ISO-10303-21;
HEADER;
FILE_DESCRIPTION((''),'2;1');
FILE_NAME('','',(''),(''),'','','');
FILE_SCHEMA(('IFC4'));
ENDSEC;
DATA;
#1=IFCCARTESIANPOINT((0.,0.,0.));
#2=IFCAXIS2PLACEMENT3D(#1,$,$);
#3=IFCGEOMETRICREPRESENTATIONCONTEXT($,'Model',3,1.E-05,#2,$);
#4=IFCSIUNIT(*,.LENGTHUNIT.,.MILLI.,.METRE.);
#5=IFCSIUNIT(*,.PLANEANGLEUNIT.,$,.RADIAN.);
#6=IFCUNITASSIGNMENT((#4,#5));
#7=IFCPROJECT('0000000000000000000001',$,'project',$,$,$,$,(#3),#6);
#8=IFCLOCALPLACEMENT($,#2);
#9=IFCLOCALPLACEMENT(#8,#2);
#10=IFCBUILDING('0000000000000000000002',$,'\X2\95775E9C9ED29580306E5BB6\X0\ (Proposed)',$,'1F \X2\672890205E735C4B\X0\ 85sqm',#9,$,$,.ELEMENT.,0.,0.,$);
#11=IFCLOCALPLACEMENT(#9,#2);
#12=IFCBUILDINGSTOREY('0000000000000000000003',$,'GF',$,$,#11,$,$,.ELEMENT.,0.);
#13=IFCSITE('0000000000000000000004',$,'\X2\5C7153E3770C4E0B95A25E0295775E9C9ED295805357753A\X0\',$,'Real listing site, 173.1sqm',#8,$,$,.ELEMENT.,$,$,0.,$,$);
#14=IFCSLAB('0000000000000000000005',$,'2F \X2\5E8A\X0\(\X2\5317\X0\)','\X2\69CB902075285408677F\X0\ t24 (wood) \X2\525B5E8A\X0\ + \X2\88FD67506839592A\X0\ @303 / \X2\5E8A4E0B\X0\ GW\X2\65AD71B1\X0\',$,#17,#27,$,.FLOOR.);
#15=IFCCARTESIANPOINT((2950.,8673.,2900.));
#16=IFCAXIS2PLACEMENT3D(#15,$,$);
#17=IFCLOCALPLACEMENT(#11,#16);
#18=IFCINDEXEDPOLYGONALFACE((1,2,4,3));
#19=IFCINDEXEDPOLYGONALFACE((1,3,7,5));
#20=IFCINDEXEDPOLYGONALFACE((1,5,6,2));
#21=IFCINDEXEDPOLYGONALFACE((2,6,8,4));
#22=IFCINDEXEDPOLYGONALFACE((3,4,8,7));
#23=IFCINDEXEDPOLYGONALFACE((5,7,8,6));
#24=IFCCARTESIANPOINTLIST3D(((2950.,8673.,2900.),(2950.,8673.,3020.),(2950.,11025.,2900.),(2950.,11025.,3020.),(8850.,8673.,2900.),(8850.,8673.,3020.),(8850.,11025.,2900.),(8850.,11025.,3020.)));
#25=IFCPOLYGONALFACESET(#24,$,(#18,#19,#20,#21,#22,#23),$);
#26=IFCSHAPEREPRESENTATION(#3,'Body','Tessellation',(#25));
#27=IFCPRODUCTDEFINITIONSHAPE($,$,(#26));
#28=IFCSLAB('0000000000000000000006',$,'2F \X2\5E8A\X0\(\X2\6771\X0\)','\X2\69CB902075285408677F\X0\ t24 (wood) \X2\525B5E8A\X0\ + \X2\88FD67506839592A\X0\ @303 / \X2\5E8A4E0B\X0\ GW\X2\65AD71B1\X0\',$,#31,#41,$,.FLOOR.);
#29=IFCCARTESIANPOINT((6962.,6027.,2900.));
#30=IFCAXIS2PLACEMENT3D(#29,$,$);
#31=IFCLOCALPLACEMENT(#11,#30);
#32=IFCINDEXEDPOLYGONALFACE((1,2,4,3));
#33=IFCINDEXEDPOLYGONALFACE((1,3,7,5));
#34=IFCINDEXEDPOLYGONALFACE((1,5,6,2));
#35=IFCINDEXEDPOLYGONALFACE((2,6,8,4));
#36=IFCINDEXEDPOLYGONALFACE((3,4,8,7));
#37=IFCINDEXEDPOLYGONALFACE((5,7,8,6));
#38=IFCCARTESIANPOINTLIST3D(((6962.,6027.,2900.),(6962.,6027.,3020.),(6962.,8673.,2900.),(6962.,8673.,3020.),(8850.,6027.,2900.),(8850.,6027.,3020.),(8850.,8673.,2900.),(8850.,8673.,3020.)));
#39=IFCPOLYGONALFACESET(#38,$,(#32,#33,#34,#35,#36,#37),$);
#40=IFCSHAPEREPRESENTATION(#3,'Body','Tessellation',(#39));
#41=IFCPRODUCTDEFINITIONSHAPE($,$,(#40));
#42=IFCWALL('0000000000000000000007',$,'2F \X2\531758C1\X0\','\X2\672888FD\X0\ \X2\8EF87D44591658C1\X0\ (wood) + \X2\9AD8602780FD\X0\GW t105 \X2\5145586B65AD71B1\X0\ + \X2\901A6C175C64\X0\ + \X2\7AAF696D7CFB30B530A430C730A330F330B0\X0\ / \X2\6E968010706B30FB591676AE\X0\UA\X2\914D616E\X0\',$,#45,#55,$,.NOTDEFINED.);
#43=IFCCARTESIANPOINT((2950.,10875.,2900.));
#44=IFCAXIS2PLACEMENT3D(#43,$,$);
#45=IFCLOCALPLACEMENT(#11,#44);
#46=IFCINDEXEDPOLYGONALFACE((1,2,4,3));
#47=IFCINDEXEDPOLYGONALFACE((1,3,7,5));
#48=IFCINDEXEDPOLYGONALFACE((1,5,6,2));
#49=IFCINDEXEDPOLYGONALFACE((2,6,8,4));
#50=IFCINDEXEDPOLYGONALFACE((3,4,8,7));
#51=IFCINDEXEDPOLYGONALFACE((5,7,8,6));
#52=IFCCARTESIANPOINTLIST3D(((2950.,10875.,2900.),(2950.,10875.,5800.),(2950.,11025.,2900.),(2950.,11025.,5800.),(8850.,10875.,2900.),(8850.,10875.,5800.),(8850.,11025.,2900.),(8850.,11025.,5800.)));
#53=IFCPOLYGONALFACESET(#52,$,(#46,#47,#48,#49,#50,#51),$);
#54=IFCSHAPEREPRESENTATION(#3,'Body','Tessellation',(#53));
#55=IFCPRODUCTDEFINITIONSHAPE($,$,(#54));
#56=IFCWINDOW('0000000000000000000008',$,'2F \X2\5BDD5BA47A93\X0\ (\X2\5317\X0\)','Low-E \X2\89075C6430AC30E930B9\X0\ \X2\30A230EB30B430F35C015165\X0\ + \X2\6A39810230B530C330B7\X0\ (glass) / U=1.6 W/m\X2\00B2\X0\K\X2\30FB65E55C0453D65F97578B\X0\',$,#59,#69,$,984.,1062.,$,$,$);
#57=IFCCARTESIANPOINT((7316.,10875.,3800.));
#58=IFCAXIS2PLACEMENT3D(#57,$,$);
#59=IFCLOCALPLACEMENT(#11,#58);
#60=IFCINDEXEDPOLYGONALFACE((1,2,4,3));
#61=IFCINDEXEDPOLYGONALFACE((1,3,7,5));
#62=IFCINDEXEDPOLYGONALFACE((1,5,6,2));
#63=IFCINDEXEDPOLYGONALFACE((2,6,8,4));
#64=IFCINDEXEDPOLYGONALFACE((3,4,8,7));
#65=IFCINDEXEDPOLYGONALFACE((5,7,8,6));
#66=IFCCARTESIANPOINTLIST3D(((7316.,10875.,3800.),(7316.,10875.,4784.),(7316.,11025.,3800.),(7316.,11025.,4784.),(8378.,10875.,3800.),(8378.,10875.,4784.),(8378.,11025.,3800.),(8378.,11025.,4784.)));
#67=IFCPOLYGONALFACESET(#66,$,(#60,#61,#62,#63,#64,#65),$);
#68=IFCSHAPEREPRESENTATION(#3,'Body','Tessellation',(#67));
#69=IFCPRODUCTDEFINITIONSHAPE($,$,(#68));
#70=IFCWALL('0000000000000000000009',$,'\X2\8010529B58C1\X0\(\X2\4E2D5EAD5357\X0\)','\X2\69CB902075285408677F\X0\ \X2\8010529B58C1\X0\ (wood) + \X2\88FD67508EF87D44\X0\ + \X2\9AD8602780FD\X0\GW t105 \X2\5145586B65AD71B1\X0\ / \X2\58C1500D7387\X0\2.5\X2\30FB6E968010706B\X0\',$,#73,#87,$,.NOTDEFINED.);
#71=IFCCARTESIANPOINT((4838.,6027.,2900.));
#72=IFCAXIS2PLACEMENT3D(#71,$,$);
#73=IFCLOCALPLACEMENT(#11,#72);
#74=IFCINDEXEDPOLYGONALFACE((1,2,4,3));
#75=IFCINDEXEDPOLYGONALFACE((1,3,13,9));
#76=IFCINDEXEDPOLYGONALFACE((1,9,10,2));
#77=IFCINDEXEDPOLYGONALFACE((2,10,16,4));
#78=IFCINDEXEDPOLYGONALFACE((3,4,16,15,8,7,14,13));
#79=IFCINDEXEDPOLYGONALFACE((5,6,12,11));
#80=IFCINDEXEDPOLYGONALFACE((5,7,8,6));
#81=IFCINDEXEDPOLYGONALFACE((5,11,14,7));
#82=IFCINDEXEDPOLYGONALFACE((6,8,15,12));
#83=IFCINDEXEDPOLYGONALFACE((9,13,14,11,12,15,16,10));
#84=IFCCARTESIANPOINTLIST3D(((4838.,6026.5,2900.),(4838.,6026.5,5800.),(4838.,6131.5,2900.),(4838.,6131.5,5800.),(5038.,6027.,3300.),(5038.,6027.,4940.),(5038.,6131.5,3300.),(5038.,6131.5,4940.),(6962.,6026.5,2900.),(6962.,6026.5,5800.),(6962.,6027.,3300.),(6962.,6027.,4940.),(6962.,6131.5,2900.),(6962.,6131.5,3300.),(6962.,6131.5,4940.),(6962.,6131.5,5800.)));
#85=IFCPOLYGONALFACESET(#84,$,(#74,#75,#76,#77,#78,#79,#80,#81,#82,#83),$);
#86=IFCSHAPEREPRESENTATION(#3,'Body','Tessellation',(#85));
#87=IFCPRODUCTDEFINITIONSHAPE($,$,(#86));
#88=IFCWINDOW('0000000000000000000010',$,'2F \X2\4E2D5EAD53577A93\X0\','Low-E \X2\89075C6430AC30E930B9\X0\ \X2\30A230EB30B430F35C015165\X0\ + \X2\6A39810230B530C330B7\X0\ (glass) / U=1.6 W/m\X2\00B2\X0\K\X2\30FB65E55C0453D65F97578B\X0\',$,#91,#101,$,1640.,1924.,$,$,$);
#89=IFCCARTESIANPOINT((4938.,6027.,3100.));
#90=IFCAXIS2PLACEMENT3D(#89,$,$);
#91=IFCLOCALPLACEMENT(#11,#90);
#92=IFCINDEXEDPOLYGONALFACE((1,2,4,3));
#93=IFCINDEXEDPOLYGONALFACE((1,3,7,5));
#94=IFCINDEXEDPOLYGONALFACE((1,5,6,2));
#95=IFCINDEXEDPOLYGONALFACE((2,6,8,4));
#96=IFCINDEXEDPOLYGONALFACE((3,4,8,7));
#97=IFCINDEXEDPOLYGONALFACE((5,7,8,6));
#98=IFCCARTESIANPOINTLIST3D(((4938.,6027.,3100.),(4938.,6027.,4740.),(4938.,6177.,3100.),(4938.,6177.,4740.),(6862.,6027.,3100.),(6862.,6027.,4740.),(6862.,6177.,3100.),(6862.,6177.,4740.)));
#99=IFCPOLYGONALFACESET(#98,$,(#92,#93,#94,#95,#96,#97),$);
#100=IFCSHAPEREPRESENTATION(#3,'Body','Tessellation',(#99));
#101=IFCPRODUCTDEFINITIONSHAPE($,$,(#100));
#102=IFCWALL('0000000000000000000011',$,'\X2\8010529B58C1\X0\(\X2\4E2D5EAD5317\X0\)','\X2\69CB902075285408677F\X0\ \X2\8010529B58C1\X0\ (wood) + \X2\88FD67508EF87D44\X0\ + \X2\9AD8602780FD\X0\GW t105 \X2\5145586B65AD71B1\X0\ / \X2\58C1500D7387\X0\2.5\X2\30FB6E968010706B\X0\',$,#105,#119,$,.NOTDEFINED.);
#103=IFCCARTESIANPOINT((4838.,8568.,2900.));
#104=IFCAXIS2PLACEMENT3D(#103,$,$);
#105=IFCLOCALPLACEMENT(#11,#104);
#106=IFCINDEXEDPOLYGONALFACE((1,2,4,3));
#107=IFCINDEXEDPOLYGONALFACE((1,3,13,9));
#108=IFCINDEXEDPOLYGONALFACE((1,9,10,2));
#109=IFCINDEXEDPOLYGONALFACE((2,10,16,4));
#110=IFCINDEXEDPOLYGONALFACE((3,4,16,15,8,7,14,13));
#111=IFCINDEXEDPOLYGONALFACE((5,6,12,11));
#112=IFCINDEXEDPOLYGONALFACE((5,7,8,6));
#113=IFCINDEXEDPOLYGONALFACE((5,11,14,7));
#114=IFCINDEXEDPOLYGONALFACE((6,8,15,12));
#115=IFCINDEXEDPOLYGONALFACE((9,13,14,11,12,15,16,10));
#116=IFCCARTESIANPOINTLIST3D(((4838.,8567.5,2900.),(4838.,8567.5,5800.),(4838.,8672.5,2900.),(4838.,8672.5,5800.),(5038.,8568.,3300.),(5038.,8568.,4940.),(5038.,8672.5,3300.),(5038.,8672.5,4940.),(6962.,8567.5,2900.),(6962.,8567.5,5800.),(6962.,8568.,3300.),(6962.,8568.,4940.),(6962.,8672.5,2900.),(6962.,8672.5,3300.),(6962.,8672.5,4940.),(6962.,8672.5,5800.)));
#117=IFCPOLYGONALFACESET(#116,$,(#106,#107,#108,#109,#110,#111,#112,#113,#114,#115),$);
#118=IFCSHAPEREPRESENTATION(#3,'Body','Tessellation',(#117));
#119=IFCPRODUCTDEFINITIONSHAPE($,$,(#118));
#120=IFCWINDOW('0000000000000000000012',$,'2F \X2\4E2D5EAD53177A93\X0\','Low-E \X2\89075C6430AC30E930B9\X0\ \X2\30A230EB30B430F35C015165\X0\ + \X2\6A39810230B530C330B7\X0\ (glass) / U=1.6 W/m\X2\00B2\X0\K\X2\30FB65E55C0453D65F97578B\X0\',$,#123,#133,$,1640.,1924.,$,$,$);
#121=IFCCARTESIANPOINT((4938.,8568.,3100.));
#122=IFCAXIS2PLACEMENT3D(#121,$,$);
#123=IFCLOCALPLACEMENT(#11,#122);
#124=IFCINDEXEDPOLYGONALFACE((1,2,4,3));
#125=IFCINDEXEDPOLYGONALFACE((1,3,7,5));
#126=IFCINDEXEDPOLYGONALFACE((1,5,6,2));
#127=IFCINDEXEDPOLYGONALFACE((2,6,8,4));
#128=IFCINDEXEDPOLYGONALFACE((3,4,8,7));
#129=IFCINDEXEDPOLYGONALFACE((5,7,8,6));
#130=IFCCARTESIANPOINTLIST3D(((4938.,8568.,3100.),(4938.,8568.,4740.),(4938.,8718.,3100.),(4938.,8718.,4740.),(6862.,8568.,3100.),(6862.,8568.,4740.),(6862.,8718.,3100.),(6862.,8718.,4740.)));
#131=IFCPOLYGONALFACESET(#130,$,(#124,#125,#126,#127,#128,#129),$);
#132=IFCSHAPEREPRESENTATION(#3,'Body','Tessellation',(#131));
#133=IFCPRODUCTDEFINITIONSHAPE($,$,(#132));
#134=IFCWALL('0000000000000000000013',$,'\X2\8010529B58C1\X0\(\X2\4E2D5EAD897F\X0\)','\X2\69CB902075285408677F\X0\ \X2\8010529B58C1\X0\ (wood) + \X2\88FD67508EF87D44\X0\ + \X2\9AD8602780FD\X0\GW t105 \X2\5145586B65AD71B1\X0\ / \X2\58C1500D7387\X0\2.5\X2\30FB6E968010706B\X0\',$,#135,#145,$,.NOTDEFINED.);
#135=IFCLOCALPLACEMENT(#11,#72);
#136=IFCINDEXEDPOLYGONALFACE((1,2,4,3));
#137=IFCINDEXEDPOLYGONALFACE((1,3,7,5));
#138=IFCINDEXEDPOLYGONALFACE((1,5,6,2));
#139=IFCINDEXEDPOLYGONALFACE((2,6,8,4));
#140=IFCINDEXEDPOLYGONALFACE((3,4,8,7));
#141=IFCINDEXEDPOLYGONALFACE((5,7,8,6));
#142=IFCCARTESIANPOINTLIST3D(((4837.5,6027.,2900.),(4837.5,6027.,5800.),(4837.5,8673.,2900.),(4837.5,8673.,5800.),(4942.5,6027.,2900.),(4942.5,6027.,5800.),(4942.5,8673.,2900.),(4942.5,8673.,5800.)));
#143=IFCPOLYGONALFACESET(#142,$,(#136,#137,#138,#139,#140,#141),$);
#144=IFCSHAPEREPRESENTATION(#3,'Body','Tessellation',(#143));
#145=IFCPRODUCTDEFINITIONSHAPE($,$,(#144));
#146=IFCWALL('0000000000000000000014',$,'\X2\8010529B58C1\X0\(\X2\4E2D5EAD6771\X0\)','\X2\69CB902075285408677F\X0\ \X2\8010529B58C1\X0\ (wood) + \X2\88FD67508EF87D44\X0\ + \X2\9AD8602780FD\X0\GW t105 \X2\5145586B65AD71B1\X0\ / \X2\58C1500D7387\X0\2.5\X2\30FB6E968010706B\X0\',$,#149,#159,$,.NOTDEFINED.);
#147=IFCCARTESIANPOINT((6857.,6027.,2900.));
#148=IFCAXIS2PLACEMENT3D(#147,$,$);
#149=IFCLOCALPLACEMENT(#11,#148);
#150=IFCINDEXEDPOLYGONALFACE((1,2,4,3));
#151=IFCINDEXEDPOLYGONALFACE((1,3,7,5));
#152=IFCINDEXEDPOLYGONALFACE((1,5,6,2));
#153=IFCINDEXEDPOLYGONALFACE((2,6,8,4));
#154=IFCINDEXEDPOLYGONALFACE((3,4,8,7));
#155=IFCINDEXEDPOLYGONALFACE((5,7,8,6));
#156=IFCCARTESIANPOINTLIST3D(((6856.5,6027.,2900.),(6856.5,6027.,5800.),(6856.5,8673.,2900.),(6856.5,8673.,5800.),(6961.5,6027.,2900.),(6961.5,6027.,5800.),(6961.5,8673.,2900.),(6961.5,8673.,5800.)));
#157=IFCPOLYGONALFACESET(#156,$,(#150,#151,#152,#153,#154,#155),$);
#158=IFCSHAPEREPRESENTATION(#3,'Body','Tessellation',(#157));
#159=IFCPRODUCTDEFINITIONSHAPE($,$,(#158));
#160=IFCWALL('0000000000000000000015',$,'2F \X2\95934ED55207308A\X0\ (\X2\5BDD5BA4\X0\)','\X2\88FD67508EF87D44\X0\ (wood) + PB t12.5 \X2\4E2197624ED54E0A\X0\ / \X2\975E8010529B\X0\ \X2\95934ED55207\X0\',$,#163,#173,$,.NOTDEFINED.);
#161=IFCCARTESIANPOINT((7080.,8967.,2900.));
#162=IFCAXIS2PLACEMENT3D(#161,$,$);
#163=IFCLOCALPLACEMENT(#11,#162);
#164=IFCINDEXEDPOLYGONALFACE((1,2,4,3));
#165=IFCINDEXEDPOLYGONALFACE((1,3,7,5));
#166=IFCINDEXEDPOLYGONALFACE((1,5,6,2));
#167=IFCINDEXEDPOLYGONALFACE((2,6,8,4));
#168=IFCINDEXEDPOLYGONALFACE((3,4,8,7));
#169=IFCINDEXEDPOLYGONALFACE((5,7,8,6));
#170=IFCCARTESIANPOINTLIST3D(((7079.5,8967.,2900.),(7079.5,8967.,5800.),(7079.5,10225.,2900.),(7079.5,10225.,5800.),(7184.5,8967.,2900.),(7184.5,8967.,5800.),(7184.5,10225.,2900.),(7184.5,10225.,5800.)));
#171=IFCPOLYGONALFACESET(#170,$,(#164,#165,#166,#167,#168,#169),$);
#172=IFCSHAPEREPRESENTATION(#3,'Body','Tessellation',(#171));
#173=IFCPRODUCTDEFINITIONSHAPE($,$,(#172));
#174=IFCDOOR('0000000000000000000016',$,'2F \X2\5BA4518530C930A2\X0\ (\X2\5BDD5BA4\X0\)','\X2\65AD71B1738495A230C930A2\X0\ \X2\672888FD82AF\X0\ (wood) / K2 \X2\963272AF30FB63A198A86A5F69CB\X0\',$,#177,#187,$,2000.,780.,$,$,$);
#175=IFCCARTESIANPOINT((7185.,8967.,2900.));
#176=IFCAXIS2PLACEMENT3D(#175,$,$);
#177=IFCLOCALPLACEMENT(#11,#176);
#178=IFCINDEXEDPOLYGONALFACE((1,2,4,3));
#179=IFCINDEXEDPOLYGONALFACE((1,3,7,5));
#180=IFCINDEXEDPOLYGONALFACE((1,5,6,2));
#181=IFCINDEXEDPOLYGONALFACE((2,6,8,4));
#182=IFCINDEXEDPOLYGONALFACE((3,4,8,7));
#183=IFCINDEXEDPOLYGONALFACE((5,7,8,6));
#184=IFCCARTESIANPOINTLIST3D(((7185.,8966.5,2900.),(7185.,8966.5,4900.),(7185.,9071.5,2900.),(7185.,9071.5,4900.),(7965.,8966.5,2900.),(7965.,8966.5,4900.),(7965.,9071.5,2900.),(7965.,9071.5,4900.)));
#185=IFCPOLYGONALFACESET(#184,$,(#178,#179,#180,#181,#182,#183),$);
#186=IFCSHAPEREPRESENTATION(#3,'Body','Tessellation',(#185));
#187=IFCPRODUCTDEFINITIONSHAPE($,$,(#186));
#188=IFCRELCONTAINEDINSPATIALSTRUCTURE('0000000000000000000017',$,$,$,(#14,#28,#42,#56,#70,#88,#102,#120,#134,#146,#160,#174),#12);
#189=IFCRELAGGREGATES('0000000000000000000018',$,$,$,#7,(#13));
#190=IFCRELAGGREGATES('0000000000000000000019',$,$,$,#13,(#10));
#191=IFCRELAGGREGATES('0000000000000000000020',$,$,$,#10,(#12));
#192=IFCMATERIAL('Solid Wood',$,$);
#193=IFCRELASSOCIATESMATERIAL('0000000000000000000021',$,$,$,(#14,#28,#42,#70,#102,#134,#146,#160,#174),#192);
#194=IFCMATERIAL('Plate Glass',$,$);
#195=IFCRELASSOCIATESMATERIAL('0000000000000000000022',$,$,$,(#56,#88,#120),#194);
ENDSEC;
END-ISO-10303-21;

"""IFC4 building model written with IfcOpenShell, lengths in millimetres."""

from ifc_helpers import new_model, si_unit, frame, frame_2d, origin, place, context, project, spatial, rectangle, extrude, material, element, fill, save


model = new_model("IFC4")

# Units and contexts
model_context = context("Model", 3, precision=1e-05, world=origin())
ifc_project = project(units=[si_unit("LENGTHUNIT", "METRE", prefix="MILLI"), si_unit("PLANEANGLEUNIT", "RADIAN")], contexts=[model_context])

# Site, building, storey
site_placement = place(None, origin())
site = spatial("IfcSite", under=ifc_project, at=site_placement, Name="山口県下関市長府黒門南町", ObjectType="Real listing site, 173.1sqm", CompositionType="ELEMENT", RefElevation=0.0)
building_placement = place(site_placement, origin())
building = spatial("IfcBuilding", under=site, at=building_placement, Name="長府黒門の家 (Proposed)", ObjectType="1F 木造平屋 85sqm", CompositionType="ELEMENT", ElevationOfRefHeight=0.0, ElevationOfTerrain=0.0)
storey_placement = place(building_placement, origin())
storey = spatial("IfcBuildingStorey", under=building, at=storey_placement, Name="GF", CompositionType="ELEMENT", Elevation=0.0)

# Slabs
ifc_material_1 = material(Name="Solid Wood")
slab_1_placement = place(storey_placement, frame((2950.0, 8673.0, 2900.0)))
element("IfcSlab", 1, at=slab_1_placement, inside=storey, material=ifc_material_1, Name="2F 床(北)", Description="構造用合板 t24 (wood) 剛床 + 製材根太 @303 / 床下 GW断熱", PredefinedType="FLOOR", context=model_context, shape_type="SweptSolid", body=[
    extrude(rectangle(XDim=5900.0, YDim=2352.0, at=frame_2d((2950.0, 1176.0))), frame((2950.0, 8673.0, 2900.0)), (0.0, 0.0, 1.0), 120.0),
])
slab_2_placement = place(storey_placement, frame((6962.0, 6027.0, 2900.0)))
element("IfcSlab", 2, at=slab_2_placement, inside=storey, material=ifc_material_1, Name="2F 床(東)", Description="構造用合板 t24 (wood) 剛床 + 製材根太 @303 / 床下 GW断熱", PredefinedType="FLOOR", context=model_context, shape_type="SweptSolid", body=[
    extrude(rectangle(XDim=1888.0, YDim=2646.0, at=frame_2d((944.0, 1323.0))), frame((6962.0, 6027.0, 2900.0)), (0.0, 0.0, 1.0), 120.0),
])

# Walls, openings, windows
wall_1_placement = place(storey_placement, frame((2950.0, 10875.0, 2900.0)))
wall_1 = element("IfcWall", 3, at=wall_1_placement, inside=storey, material=ifc_material_1, Name="2F 北壁", Description="木製 軸組外壁 (wood) + 高性能GW t105 充填断熱 + 通気層 + 窯業系サイディング / 準耐火・外皮UA配慮", PredefinedType="NOTDEFINED", context=model_context, shape_type="SweptSolid", body=[
    extrude(rectangle(XDim=5900.0, YDim=150.0, at=frame_2d((2950.0, 75.0))), frame((2950.0, 10875.0, 2900.0)), (0.0, 0.0, 1.0), 2900.0),
])
opening_1_placement = place(storey_placement, frame((7316.0, 10875.0, 3800.0)))
opening_1 = element("IfcOpeningElement", 4, at=opening_1_placement, cuts=wall_1, PredefinedType="NOTDEFINED", context=model_context, shape_type="SweptSolid", body=[
    extrude(rectangle(XDim=1062.0, YDim=150.0, at=frame_2d((531.0, 75.0))), frame((7316.0, 10875.0, 3800.0)), (0.0, 0.0, 1.0), 984.0),
])
ifc_material_2 = material(Name="Plate Glass")
window_1_placement = place(storey_placement, frame((7316.0, 10875.0, 3800.0)))
window_1 = element("IfcWindow", 5, at=window_1_placement, inside=storey, material=ifc_material_2, Name="2F 寝室窓 (北)", Description="Low-E 複層ガラス アルゴン封入 + 樹脂サッシ (glass) / U=1.6 W/m²K・日射取得型", OverallHeight=984.0, OverallWidth=1062.0, context=model_context, shape_type="SweptSolid", body=[
    extrude(rectangle(XDim=1062.0, YDim=150.0, at=frame_2d((531.0, 75.0))), frame((7316.0, 10875.0, 3800.0)), (0.0, 0.0, 1.0), 984.0),
])
fill(opening_1, window_1)
wall_2_placement = place(storey_placement, frame((4838.0, 6027.0, 2900.0)))
wall_2 = element("IfcWall", 6, at=wall_2_placement, inside=storey, material=ifc_material_1, Name="耐力壁(中庭南)", Description="構造用合板 耐力壁 (wood) + 製材軸組 + 高性能GW t105 充填断熱 / 壁倍率2.5・準耐火", PredefinedType="NOTDEFINED", context=model_context, shape_type="SweptSolid", body=[
    extrude(rectangle(XDim=2124.0, YDim=105.0, at=frame_2d((1062.0, 52.0))), frame((4838.0, 6027.0, 2900.0)), (0.0, 0.0, 1.0), 2900.0),
])
opening_2_placement = place(storey_placement, frame((4938.0, 6027.0, 3100.0)))
opening_2 = element("IfcOpeningElement", 7, at=opening_2_placement, cuts=wall_2, PredefinedType="NOTDEFINED", context=model_context, shape_type="SweptSolid", body=[
    extrude(rectangle(XDim=1924.0, YDim=150.0, at=frame_2d((962.0, 75.0))), frame((4938.0, 6027.0, 3100.0)), (0.0, 0.0, 1.0), 1640.0),
])
window_2_placement = place(storey_placement, frame((4938.0, 6027.0, 3100.0)))
window_2 = element("IfcWindow", 8, at=window_2_placement, inside=storey, material=ifc_material_2, Name="2F 中庭南窓", Description="Low-E 複層ガラス アルゴン封入 + 樹脂サッシ (glass) / U=1.6 W/m²K・日射取得型", OverallHeight=1640.0, OverallWidth=1924.0, context=model_context, shape_type="SweptSolid", body=[
    extrude(rectangle(XDim=1924.0, YDim=150.0, at=frame_2d((962.0, 75.0))), frame((4938.0, 6027.0, 3100.0)), (0.0, 0.0, 1.0), 1640.0),
])
fill(opening_2, window_2)
wall_3_placement = place(storey_placement, frame((4838.0, 8568.0, 2900.0)))
wall_3 = element("IfcWall", 9, at=wall_3_placement, inside=storey, material=ifc_material_1, Name="耐力壁(中庭北)", Description="構造用合板 耐力壁 (wood) + 製材軸組 + 高性能GW t105 充填断熱 / 壁倍率2.5・準耐火", PredefinedType="NOTDEFINED", context=model_context, shape_type="SweptSolid", body=[
    extrude(rectangle(XDim=2124.0, YDim=105.0, at=frame_2d((1062.0, 52.0))), frame((4838.0, 8568.0, 2900.0)), (0.0, 0.0, 1.0), 2900.0),
])
opening_3_placement = place(storey_placement, frame((4938.0, 8568.0, 3100.0)))
opening_3 = element("IfcOpeningElement", 10, at=opening_3_placement, cuts=wall_3, PredefinedType="NOTDEFINED", context=model_context, shape_type="SweptSolid", body=[
    extrude(rectangle(XDim=1924.0, YDim=150.0, at=frame_2d((962.0, 75.0))), frame((4938.0, 8568.0, 3100.0)), (0.0, 0.0, 1.0), 1640.0),
])
window_3_placement = place(storey_placement, frame((4938.0, 8568.0, 3100.0)))
window_3 = element("IfcWindow", 11, at=window_3_placement, inside=storey, material=ifc_material_2, Name="2F 中庭北窓", Description="Low-E 複層ガラス アルゴン封入 + 樹脂サッシ (glass) / U=1.6 W/m²K・日射取得型", OverallHeight=1640.0, OverallWidth=1924.0, context=model_context, shape_type="SweptSolid", body=[
    extrude(rectangle(XDim=1924.0, YDim=150.0, at=frame_2d((962.0, 75.0))), frame((4938.0, 8568.0, 3100.0)), (0.0, 0.0, 1.0), 1640.0),
])
fill(opening_3, window_3)

# Walls
wall_4_placement = place(storey_placement, frame((4838.0, 6027.0, 2900.0)))
element("IfcWall", 12, at=wall_4_placement, inside=storey, material=ifc_material_1, Name="耐力壁(中庭西)", Description="構造用合板 耐力壁 (wood) + 製材軸組 + 高性能GW t105 充填断熱 / 壁倍率2.5・準耐火", PredefinedType="NOTDEFINED", context=model_context, shape_type="SweptSolid", body=[
    extrude(rectangle(XDim=105.0, YDim=2646.0, at=frame_2d((52.0, 1323.0))), frame((4838.0, 6027.0, 2900.0)), (0.0, 0.0, 1.0), 2900.0),
])
wall_5_placement = place(storey_placement, frame((6857.0, 6027.0, 2900.0)))
element("IfcWall", 13, at=wall_5_placement, inside=storey, material=ifc_material_1, Name="耐力壁(中庭東)", Description="構造用合板 耐力壁 (wood) + 製材軸組 + 高性能GW t105 充填断熱 / 壁倍率2.5・準耐火", PredefinedType="NOTDEFINED", context=model_context, shape_type="SweptSolid", body=[
    extrude(rectangle(XDim=105.0, YDim=2646.0, at=frame_2d((52.0, 1323.0))), frame((6857.0, 6027.0, 2900.0)), (0.0, 0.0, 1.0), 2900.0),
])
wall_6_placement = place(storey_placement, frame((7080.0, 8967.0, 2900.0)))
element("IfcWall", 14, at=wall_6_placement, inside=storey, material=ifc_material_1, Name="2F 間仕切り (寝室)", Description="製材軸組 (wood) + PB t12.5 両面仕上 / 非耐力 間仕切", PredefinedType="NOTDEFINED", context=model_context, shape_type="SweptSolid", body=[
    extrude(rectangle(XDim=105.0, YDim=1258.0, at=frame_2d((52.0, 629.0))), frame((7080.0, 8967.0, 2900.0)), (0.0, 0.0, 1.0), 2900.0),
])

# Door
door_placement = place(storey_placement, frame((7185.0, 8967.0, 2900.0)))
element("IfcDoor", 15, at=door_placement, inside=storey, material=ifc_material_1, Name="2F 室内ドア (寝室)", Description="断熱玄関ドア 木製芯 (wood) / K2 防犯・採風機構", OverallHeight=2000.0, OverallWidth=780.0, context=model_context, shape_type="SweptSolid", body=[
    extrude(rectangle(XDim=780.0, YDim=105.0, at=frame_2d((390.0, 52.0))), frame((7185.0, 8967.0, 2900.0)), (0.0, 0.0, 1.0), 2000.0),
])

save(model, "model.ifc")
